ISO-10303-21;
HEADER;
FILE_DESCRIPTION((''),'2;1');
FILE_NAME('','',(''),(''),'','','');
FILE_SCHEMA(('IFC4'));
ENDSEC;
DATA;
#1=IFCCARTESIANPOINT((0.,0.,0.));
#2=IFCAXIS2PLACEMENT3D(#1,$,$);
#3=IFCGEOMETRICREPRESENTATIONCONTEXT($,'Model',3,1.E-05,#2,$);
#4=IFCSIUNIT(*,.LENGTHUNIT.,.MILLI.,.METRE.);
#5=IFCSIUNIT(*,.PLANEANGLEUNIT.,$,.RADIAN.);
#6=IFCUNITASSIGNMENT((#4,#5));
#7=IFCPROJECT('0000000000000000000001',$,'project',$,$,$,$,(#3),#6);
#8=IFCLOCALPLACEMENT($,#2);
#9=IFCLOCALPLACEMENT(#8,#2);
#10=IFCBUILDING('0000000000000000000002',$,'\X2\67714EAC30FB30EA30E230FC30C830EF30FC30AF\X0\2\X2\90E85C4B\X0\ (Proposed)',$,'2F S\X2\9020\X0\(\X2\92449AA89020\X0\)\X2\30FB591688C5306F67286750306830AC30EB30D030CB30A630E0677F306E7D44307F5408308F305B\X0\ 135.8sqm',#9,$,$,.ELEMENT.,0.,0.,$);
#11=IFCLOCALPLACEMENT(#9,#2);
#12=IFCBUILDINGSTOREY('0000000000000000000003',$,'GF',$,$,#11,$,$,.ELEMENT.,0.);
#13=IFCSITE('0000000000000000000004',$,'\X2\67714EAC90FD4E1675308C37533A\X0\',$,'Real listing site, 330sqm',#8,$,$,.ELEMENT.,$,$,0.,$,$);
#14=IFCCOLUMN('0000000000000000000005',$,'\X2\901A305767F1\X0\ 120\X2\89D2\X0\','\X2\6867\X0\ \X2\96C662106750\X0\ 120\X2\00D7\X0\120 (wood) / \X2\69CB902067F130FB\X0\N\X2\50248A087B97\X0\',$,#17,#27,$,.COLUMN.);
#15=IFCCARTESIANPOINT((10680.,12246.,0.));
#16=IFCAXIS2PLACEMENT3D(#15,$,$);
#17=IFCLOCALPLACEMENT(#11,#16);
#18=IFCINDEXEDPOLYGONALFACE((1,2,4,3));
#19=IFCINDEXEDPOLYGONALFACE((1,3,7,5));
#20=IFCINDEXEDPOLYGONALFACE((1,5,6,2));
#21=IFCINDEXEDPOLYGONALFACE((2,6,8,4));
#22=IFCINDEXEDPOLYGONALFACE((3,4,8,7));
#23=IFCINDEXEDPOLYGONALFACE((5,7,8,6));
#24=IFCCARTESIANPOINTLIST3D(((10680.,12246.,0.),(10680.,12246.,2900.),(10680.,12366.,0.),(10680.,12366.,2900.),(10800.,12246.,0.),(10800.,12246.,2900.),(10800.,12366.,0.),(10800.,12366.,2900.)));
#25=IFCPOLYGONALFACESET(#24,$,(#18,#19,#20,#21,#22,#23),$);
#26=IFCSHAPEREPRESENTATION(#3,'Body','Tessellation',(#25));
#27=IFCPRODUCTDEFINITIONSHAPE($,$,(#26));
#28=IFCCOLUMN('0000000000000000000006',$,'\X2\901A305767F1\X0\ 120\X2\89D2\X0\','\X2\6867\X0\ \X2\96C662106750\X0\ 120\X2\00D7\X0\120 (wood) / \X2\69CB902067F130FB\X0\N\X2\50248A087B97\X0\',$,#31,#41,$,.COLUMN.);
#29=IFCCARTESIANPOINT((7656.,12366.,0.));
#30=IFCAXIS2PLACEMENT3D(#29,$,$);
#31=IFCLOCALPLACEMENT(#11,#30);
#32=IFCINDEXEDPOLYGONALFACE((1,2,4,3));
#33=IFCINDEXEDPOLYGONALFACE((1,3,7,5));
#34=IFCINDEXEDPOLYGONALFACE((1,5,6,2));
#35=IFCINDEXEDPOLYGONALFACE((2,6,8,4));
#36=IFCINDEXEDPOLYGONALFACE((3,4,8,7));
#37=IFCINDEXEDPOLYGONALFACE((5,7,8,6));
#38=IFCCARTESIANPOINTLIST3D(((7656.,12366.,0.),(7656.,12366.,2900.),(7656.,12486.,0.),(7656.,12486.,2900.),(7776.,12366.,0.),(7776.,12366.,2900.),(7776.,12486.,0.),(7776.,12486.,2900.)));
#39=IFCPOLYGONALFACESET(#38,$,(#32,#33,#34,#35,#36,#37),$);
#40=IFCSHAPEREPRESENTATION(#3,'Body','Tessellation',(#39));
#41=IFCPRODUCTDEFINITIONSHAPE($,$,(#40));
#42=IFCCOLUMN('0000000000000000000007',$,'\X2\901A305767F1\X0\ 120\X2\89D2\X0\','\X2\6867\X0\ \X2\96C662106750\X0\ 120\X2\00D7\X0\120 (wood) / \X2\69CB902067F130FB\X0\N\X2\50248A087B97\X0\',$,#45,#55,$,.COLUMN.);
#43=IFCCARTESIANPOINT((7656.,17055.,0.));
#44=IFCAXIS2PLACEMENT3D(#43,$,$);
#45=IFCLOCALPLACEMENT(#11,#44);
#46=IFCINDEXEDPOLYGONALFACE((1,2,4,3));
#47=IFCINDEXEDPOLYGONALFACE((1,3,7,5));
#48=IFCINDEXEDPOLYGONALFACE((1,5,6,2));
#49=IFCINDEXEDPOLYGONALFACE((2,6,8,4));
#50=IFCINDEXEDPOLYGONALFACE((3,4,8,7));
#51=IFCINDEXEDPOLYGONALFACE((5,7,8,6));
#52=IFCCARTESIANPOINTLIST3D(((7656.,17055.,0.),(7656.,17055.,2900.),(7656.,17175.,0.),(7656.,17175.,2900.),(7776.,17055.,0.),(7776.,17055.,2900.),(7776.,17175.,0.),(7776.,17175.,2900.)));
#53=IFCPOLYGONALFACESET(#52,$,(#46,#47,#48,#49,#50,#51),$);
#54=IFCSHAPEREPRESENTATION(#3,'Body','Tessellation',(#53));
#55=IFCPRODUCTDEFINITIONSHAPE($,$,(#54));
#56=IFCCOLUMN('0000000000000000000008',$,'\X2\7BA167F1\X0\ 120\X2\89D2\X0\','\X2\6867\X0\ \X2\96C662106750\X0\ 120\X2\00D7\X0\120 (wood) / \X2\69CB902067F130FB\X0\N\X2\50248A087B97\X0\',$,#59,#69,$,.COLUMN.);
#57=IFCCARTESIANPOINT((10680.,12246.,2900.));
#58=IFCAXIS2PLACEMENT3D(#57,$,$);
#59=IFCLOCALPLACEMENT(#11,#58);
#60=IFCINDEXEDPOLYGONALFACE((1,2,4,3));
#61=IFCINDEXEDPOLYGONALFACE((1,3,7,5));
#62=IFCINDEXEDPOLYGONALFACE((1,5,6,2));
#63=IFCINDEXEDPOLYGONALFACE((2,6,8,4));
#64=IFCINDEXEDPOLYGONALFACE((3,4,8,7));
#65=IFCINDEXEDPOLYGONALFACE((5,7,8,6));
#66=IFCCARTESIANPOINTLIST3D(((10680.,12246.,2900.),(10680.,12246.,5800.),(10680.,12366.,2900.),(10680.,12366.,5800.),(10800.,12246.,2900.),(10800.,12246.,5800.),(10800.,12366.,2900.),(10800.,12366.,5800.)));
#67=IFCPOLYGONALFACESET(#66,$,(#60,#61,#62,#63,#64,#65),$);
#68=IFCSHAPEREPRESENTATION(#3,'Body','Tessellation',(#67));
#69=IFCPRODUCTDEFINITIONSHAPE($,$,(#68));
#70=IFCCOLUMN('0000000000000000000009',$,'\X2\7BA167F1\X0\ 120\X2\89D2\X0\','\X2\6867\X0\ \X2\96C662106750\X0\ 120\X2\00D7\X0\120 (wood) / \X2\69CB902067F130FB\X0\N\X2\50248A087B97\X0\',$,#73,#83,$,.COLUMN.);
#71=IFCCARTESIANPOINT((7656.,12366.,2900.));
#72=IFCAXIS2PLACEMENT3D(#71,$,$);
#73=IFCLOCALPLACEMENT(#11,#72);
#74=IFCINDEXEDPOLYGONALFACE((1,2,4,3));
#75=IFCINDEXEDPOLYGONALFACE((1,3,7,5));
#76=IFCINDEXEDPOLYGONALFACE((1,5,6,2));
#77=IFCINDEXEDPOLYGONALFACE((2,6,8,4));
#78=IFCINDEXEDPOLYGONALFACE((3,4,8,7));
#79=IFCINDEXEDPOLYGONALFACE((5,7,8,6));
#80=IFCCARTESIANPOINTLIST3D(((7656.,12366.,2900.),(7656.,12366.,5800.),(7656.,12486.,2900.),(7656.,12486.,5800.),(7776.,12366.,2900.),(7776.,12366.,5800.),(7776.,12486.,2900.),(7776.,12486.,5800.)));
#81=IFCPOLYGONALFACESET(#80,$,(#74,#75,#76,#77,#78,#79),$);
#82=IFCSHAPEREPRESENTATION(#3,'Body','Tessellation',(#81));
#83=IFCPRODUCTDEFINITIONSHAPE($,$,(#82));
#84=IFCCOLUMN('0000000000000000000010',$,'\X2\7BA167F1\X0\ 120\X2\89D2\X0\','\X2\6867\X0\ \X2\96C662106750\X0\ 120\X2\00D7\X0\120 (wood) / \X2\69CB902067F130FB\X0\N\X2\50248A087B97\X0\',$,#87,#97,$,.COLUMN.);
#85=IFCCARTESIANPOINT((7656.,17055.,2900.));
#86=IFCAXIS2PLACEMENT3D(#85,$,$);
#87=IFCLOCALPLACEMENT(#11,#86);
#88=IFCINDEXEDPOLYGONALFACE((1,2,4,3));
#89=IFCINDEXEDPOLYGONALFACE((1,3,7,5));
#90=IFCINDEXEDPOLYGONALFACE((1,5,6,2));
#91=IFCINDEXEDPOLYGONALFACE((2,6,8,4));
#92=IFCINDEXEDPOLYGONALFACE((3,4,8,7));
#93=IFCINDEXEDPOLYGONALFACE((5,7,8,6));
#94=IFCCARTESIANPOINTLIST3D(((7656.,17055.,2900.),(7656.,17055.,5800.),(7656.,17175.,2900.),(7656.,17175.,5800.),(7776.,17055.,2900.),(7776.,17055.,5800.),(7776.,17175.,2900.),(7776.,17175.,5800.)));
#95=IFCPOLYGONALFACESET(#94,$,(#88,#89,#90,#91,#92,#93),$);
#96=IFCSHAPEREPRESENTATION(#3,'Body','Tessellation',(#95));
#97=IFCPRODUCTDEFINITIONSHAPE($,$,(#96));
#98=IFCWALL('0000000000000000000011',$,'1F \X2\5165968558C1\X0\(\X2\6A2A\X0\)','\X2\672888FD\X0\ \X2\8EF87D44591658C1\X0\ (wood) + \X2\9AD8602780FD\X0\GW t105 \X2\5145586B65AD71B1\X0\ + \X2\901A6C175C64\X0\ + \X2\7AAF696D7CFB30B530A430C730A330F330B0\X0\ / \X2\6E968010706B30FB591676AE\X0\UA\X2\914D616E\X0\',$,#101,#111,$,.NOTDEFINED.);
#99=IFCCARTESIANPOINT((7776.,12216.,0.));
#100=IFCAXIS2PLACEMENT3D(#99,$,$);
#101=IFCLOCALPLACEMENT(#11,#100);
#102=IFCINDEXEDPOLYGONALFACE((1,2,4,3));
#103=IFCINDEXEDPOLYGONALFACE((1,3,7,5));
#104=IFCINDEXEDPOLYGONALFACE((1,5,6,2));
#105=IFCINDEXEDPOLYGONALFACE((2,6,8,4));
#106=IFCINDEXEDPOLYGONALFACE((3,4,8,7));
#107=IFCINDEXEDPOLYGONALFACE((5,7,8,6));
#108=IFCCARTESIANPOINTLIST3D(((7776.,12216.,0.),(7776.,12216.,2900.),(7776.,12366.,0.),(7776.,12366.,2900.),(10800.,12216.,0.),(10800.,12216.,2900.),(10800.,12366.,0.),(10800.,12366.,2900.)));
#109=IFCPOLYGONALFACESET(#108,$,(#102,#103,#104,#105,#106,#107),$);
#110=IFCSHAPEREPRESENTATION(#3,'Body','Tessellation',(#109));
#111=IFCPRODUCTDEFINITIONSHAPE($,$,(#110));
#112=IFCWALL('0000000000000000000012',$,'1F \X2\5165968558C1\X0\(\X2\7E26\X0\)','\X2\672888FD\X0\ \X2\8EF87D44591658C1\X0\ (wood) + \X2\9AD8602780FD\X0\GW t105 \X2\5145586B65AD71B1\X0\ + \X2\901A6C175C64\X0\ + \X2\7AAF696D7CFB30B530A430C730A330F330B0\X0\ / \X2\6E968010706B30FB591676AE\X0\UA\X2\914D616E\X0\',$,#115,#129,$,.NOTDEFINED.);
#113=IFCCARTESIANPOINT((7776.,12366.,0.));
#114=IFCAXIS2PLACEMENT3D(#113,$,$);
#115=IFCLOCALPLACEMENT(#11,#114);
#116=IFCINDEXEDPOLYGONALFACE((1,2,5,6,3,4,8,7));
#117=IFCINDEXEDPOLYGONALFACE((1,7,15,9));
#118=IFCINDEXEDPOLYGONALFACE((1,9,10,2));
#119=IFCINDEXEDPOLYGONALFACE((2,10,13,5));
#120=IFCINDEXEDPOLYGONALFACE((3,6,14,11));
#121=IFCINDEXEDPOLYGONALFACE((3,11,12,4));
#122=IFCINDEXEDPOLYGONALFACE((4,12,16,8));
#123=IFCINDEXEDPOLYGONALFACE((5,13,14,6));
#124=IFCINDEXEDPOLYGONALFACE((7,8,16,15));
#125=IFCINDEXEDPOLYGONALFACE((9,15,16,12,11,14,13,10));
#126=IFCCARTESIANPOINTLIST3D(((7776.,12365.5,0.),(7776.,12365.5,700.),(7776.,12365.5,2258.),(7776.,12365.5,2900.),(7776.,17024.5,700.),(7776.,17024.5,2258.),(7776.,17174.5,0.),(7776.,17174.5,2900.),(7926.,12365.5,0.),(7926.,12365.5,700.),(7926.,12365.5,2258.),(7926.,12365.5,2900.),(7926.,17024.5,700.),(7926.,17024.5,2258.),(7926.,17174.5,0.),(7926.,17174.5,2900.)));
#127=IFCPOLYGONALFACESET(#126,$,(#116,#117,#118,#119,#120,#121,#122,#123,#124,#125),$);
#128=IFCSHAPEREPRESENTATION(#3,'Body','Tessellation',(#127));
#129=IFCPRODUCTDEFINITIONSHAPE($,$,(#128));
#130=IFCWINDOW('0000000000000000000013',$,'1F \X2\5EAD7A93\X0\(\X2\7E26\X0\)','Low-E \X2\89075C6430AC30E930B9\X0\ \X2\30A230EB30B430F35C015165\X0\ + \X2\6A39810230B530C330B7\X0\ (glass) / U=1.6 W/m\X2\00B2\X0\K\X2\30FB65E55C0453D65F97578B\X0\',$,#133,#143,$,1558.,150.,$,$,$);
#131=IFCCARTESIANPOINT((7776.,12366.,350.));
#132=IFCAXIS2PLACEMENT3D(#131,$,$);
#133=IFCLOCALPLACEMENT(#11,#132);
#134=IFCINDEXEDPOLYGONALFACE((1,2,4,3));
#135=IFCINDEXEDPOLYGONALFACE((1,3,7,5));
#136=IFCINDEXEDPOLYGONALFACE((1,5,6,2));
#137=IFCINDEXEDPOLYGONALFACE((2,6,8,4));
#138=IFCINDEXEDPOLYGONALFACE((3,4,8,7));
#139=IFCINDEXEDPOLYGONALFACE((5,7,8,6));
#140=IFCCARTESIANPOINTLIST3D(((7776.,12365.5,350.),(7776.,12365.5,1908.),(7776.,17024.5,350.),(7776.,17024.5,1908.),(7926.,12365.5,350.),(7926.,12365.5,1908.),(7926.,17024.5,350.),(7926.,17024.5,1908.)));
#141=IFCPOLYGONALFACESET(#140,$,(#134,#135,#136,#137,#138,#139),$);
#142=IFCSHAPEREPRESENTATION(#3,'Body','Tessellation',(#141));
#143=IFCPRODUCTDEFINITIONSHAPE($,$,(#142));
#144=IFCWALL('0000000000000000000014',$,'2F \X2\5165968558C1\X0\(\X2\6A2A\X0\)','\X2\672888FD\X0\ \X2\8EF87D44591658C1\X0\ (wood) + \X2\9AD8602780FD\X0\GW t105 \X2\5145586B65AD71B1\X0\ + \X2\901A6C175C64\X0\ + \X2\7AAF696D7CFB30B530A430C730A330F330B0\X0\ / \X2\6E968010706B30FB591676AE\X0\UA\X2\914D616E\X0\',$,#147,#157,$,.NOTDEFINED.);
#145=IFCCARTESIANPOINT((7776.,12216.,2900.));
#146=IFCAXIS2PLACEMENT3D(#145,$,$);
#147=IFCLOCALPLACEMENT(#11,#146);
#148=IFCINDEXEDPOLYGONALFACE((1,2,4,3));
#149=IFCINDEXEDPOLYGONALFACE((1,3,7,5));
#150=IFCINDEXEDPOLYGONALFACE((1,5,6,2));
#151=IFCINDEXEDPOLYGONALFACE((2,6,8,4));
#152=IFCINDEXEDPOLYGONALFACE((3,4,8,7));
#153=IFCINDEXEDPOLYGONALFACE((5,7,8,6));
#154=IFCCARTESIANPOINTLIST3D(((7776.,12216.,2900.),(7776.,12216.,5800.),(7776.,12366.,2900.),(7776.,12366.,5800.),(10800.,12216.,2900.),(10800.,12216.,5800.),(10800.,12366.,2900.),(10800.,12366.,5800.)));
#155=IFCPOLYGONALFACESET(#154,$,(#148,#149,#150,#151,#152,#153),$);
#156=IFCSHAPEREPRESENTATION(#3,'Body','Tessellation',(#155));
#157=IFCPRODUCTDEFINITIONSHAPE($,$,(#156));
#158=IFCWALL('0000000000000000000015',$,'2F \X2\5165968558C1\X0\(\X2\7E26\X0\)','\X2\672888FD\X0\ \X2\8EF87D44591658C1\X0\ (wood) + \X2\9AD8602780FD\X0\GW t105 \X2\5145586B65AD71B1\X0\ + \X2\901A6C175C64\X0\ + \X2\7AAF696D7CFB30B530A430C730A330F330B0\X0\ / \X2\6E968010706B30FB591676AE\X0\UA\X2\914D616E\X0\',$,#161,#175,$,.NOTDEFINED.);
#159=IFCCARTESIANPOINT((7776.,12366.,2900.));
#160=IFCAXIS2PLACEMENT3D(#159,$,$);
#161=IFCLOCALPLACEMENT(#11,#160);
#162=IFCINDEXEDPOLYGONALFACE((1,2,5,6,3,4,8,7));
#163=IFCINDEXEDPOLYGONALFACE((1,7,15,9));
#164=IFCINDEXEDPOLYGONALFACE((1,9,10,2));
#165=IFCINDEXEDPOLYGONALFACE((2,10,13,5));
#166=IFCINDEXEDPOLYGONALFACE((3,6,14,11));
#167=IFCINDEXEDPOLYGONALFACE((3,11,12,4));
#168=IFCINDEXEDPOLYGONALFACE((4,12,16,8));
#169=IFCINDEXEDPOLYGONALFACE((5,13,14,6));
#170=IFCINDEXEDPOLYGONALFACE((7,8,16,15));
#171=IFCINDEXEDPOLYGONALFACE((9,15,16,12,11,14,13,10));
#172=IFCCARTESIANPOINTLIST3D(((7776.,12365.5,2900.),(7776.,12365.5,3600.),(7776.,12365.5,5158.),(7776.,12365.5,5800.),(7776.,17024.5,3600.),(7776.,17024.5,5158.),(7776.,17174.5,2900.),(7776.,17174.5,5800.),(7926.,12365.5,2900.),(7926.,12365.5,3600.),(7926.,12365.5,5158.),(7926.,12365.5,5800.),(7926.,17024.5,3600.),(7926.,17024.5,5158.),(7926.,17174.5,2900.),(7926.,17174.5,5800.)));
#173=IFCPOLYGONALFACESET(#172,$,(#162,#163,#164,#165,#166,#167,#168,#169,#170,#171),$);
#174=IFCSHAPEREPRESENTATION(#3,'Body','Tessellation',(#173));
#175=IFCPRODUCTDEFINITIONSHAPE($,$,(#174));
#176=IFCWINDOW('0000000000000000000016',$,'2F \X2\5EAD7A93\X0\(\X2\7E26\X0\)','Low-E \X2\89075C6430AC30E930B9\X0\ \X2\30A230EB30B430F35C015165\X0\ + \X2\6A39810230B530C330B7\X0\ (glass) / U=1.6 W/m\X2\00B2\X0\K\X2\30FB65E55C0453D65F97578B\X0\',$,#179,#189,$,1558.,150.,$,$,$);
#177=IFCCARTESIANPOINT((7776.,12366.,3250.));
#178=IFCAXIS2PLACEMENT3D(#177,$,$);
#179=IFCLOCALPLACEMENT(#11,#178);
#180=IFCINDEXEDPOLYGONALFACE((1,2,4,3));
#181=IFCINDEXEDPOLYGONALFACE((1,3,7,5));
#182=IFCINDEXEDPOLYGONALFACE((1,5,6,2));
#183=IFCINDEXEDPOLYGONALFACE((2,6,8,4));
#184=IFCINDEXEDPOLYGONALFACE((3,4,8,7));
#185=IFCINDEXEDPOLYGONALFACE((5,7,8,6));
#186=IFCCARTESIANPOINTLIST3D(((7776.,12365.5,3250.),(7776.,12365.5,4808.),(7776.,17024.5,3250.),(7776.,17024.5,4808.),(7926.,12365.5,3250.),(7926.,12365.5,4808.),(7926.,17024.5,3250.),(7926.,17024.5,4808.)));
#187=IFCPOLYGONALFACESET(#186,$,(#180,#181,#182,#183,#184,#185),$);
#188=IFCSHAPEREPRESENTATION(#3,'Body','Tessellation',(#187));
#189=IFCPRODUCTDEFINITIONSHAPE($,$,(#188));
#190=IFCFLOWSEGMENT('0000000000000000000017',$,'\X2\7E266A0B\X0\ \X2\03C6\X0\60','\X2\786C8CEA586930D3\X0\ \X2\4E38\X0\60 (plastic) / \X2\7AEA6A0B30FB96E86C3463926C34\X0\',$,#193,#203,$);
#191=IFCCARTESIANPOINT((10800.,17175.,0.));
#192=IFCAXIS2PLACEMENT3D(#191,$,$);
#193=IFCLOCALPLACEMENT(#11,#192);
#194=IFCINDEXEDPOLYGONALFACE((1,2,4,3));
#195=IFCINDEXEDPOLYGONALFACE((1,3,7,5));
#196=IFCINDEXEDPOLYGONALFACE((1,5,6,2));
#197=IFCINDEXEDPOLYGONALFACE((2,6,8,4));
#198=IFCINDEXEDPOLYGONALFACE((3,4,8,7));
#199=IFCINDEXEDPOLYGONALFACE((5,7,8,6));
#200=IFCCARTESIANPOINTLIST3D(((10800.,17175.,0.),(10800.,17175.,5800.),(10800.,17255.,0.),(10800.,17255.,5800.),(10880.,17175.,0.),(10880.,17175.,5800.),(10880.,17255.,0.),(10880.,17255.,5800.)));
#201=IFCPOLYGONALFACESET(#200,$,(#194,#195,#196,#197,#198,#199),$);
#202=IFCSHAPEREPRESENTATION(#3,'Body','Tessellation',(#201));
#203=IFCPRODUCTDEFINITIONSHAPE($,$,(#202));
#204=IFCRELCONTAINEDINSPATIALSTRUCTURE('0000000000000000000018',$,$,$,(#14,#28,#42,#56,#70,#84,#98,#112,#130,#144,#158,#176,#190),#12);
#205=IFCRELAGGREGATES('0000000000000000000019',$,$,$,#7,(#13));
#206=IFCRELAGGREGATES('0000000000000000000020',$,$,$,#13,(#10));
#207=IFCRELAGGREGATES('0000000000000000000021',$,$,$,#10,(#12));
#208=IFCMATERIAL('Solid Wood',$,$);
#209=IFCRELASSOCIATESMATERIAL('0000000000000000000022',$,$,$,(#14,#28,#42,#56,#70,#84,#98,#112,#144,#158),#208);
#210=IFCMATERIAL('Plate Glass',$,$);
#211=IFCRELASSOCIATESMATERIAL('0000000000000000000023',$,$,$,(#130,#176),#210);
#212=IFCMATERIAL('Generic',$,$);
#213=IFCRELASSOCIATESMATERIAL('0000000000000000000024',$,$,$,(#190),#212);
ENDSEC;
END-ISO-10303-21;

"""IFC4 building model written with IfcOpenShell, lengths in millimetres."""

from ifc_helpers import new_model, si_unit, frame, frame_2d, origin, place, context, project, spatial, rectangle, extrude, material, element, fill, save


model = new_model("IFC4")

# Units and contexts
model_context = context("Model", 3, precision=1e-05, world=origin())
ifc_project = project(units=[si_unit("LENGTHUNIT", "METRE", prefix="MILLI"), si_unit("PLANEANGLEUNIT", "RADIAN")], contexts=[model_context])

# Site, building, storey
site_placement = place(None, origin())
site = spatial("IfcSite", under=ifc_project, at=site_placement, Name="東京都世田谷区", ObjectType="Real listing site, 330sqm", CompositionType="ELEMENT", RefElevation=0.0)
building_placement = place(site_placement, origin())
building = spatial("IfcBuilding", under=site, at=building_placement, Name="東京・リモートワーク2部屋 (Proposed)", ObjectType="2F S造(鉄骨造)・外装は木材とガルバニウム板の組み合わせ 135.8sqm", CompositionType="ELEMENT", ElevationOfRefHeight=0.0, ElevationOfTerrain=0.0)
storey_placement = place(building_placement, origin())
storey = spatial("IfcBuildingStorey", under=building, at=storey_placement, Name="GF", CompositionType="ELEMENT", Elevation=0.0)

# Columns
ifc_material_1 = material(Name="Solid Wood")
column_1_placement = place(storey_placement, frame((10680.0, 12246.0, 0.0)))
element("IfcColumn", 1, at=column_1_placement, inside=storey, material=ifc_material_1, Name="通し柱 120角", Description="桧 集成材 120×120 (wood) / 構造柱・N値計算", PredefinedType="COLUMN", context=model_context, shape_type="SweptSolid", body=[
    extrude(rectangle(XDim=120.0, YDim=120.0, at=frame_2d((60.0, 60.0))), frame((10680.0, 12246.0, 0.0)), (0.0, 0.0, 1.0), 2900.0),
])
column_2_placement = place(storey_placement, frame((7656.0, 12366.0, 0.0)))
element("IfcColumn", 2, at=column_2_placement, inside=storey, material=ifc_material_1, Name="通し柱 120角", Description="桧 集成材 120×120 (wood) / 構造柱・N値計算", PredefinedType="COLUMN", context=model_context, shape_type="SweptSolid", body=[
    extrude(rectangle(XDim=120.0, YDim=120.0, at=frame_2d((60.0, 60.0))), frame((7656.0, 12366.0, 0.0)), (0.0, 0.0, 1.0), 2900.0),
])
column_3_placement = place(storey_placement, frame((7656.0, 17055.0, 0.0)))
element("IfcColumn", 3, at=column_3_placement, inside=storey, material=ifc_material_1, Name="通し柱 120角", Description="桧 集成材 120×120 (wood) / 構造柱・N値計算", PredefinedType="COLUMN", context=model_context, shape_type="SweptSolid", body=[
    extrude(rectangle(XDim=120.0, YDim=120.0, at=frame_2d((60.0, 60.0))), frame((7656.0, 17055.0, 0.0)), (0.0, 0.0, 1.0), 2900.0),
])
column_4_placement = place(storey_placement, frame((10680.0, 12246.0, 2900.0)))
element("IfcColumn", 4, at=column_4_placement, inside=storey, material=ifc_material_1, Name="管柱 120角", Description="桧 集成材 120×120 (wood) / 構造柱・N値計算", PredefinedType="COLUMN", context=model_context, shape_type="SweptSolid", body=[
    extrude(rectangle(XDim=120.0, YDim=120.0, at=frame_2d((60.0, 60.0))), frame((10680.0, 12246.0, 2900.0)), (0.0, 0.0, 1.0), 2900.0),
])
column_5_placement = place(storey_placement, frame((7656.0, 12366.0, 2900.0)))
element("IfcColumn", 5, at=column_5_placement, inside=storey, material=ifc_material_1, Name="管柱 120角", Description="桧 集成材 120×120 (wood) / 構造柱・N値計算", PredefinedType="COLUMN", context=model_context, shape_type="SweptSolid", body=[
    extrude(rectangle(XDim=120.0, YDim=120.0, at=frame_2d((60.0, 60.0))), frame((7656.0, 12366.0, 2900.0)), (0.0, 0.0, 1.0), 2900.0),
])
column_6_placement = place(storey_placement, frame((7656.0, 17055.0, 2900.0)))
element("IfcColumn", 6, at=column_6_placement, inside=storey, material=ifc_material_1, Name="管柱 120角", Description="桧 集成材 120×120 (wood) / 構造柱・N値計算", PredefinedType="COLUMN", context=model_context, shape_type="SweptSolid", body=[
    extrude(rectangle(XDim=120.0, YDim=120.0, at=frame_2d((60.0, 60.0))), frame((7656.0, 17055.0, 2900.0)), (0.0, 0.0, 1.0), 2900.0),
])

# Wall
wall_1_placement = place(storey_placement, frame((7776.0, 12216.0, 0.0)))
element("IfcWall", 7, at=wall_1_placement, inside=storey, material=ifc_material_1, Name="1F 入隅壁(横)", Description="木製 軸組外壁 (wood) + 高性能GW t105 充填断熱 + 通気層 + 窯業系サイディング / 準耐火・外皮UA配慮", PredefinedType="NOTDEFINED", context=model_context, shape_type="SweptSolid", body=[
    extrude(rectangle(XDim=3024.0, YDim=150.0, at=frame_2d((1512.0, 75.0))), frame((7776.0, 12216.0, 0.0)), (0.0, 0.0, 1.0), 2900.0),
])

# Wall, opening, window
wall_2_placement = place(storey_placement, frame((7776.0, 12366.0, 0.0)))
wall_2 = element("IfcWall", 8, at=wall_2_placement, inside=storey, material=ifc_material_1, Name="1F 入隅壁(縦)", Description="木製 軸組外壁 (wood) + 高性能GW t105 充填断熱 + 通気層 + 窯業系サイディング / 準耐火・外皮UA配慮", PredefinedType="NOTDEFINED", context=model_context, shape_type="SweptSolid", body=[
    extrude(rectangle(XDim=150.0, YDim=4809.0, at=frame_2d((75.0, 2404.0))), frame((7776.0, 12366.0, 0.0)), (0.0, 0.0, 1.0), 2900.0),
])
opening_1_placement = place(storey_placement, frame((7776.0, 12366.0, 350.0)))
opening_1 = element("IfcOpeningElement", 9, at=opening_1_placement, cuts=wall_2, PredefinedType="NOTDEFINED", context=model_context, shape_type="SweptSolid", body=[
    extrude(rectangle(XDim=150.0, YDim=4659.0, at=frame_2d((75.0, 2329.0))), frame((7776.0, 12366.0, 350.0)), (0.0, 0.0, 1.0), 1558.0),
])
ifc_material_2 = material(Name="Plate Glass")
window_1_placement = place(storey_placement, frame((7776.0, 12366.0, 350.0)))
window_1 = element("IfcWindow", 10, at=window_1_placement, inside=storey, material=ifc_material_2, Name="1F 庭窓(縦)", Description="Low-E 複層ガラス アルゴン封入 + 樹脂サッシ (glass) / U=1.6 W/m²K・日射取得型", OverallHeight=1558.0, OverallWidth=150.0, context=model_context, shape_type="SweptSolid", body=[
    extrude(rectangle(XDim=150.0, YDim=4659.0, at=frame_2d((75.0, 2329.0))), frame((7776.0, 12366.0, 350.0)), (0.0, 0.0, 1.0), 1558.0),
])
fill(opening_1, window_1)

# Wall
wall_3_placement = place(storey_placement, frame((7776.0, 12216.0, 2900.0)))
element("IfcWall", 11, at=wall_3_placement, inside=storey, material=ifc_material_1, Name="2F 入隅壁(横)", Description="木製 軸組外壁 (wood) + 高性能GW t105 充填断熱 + 通気層 + 窯業系サイディング / 準耐火・外皮UA配慮", PredefinedType="NOTDEFINED", context=model_context, shape_type="SweptSolid", body=[
    extrude(rectangle(XDim=3024.0, YDim=150.0, at=frame_2d((1512.0, 75.0))), frame((7776.0, 12216.0, 2900.0)), (0.0, 0.0, 1.0), 2900.0),
])

# Wall, opening, window
wall_4_placement = place(storey_placement, frame((7776.0, 12366.0, 2900.0)))
wall_4 = element("IfcWall", 12, at=wall_4_placement, inside=storey, material=ifc_material_1, Name="2F 入隅壁(縦)", Description="木製 軸組外壁 (wood) + 高性能GW t105 充填断熱 + 通気層 + 窯業系サイディング / 準耐火・外皮UA配慮", PredefinedType="NOTDEFINED", context=model_context, shape_type="SweptSolid", body=[
    extrude(rectangle(XDim=150.0, YDim=4809.0, at=frame_2d((75.0, 2404.0))), frame((7776.0, 12366.0, 2900.0)), (0.0, 0.0, 1.0), 2900.0),
])
opening_2_placement = place(storey_placement, frame((7776.0, 12366.0, 3250.0)))
opening_2 = element("IfcOpeningElement", 13, at=opening_2_placement, cuts=wall_4, PredefinedType="NOTDEFINED", context=model_context, shape_type="SweptSolid", body=[
    extrude(rectangle(XDim=150.0, YDim=4659.0, at=frame_2d((75.0, 2329.0))), frame((7776.0, 12366.0, 3250.0)), (0.0, 0.0, 1.0), 1558.0),
])
window_2_placement = place(storey_placement, frame((7776.0, 12366.0, 3250.0)))
window_2 = element("IfcWindow", 14, at=window_2_placement, inside=storey, material=ifc_material_2, Name="2F 庭窓(縦)", Description="Low-E 複層ガラス アルゴン封入 + 樹脂サッシ (glass) / U=1.6 W/m²K・日射取得型", OverallHeight=1558.0, OverallWidth=150.0, context=model_context, shape_type="SweptSolid", body=[
    extrude(rectangle(XDim=150.0, YDim=4659.0, at=frame_2d((75.0, 2329.0))), frame((7776.0, 12366.0, 3250.0)), (0.0, 0.0, 1.0), 1558.0),
])
fill(opening_2, window_2)

# Flow segment
ifc_material_3 = material(Name="Generic")
flow_segment_placement = place(storey_placement, frame((10800.0, 17175.0, 0.0)))
element("IfcFlowSegment", 15, at=flow_segment_placement, inside=storey, material=ifc_material_3, Name="縦樋 φ60", Description="硬質塩ビ 丸60 (plastic) / 竪樋・雨水排水", context=model_context, shape_type="SweptSolid", body=[
    extrude(rectangle(XDim=80.0, YDim=80.0, at=frame_2d((40.0, 40.0))), frame((10800.0, 17175.0, 0.0)), (0.0, 0.0, 1.0), 5800.0),
])

save(model, "model.ifc")
